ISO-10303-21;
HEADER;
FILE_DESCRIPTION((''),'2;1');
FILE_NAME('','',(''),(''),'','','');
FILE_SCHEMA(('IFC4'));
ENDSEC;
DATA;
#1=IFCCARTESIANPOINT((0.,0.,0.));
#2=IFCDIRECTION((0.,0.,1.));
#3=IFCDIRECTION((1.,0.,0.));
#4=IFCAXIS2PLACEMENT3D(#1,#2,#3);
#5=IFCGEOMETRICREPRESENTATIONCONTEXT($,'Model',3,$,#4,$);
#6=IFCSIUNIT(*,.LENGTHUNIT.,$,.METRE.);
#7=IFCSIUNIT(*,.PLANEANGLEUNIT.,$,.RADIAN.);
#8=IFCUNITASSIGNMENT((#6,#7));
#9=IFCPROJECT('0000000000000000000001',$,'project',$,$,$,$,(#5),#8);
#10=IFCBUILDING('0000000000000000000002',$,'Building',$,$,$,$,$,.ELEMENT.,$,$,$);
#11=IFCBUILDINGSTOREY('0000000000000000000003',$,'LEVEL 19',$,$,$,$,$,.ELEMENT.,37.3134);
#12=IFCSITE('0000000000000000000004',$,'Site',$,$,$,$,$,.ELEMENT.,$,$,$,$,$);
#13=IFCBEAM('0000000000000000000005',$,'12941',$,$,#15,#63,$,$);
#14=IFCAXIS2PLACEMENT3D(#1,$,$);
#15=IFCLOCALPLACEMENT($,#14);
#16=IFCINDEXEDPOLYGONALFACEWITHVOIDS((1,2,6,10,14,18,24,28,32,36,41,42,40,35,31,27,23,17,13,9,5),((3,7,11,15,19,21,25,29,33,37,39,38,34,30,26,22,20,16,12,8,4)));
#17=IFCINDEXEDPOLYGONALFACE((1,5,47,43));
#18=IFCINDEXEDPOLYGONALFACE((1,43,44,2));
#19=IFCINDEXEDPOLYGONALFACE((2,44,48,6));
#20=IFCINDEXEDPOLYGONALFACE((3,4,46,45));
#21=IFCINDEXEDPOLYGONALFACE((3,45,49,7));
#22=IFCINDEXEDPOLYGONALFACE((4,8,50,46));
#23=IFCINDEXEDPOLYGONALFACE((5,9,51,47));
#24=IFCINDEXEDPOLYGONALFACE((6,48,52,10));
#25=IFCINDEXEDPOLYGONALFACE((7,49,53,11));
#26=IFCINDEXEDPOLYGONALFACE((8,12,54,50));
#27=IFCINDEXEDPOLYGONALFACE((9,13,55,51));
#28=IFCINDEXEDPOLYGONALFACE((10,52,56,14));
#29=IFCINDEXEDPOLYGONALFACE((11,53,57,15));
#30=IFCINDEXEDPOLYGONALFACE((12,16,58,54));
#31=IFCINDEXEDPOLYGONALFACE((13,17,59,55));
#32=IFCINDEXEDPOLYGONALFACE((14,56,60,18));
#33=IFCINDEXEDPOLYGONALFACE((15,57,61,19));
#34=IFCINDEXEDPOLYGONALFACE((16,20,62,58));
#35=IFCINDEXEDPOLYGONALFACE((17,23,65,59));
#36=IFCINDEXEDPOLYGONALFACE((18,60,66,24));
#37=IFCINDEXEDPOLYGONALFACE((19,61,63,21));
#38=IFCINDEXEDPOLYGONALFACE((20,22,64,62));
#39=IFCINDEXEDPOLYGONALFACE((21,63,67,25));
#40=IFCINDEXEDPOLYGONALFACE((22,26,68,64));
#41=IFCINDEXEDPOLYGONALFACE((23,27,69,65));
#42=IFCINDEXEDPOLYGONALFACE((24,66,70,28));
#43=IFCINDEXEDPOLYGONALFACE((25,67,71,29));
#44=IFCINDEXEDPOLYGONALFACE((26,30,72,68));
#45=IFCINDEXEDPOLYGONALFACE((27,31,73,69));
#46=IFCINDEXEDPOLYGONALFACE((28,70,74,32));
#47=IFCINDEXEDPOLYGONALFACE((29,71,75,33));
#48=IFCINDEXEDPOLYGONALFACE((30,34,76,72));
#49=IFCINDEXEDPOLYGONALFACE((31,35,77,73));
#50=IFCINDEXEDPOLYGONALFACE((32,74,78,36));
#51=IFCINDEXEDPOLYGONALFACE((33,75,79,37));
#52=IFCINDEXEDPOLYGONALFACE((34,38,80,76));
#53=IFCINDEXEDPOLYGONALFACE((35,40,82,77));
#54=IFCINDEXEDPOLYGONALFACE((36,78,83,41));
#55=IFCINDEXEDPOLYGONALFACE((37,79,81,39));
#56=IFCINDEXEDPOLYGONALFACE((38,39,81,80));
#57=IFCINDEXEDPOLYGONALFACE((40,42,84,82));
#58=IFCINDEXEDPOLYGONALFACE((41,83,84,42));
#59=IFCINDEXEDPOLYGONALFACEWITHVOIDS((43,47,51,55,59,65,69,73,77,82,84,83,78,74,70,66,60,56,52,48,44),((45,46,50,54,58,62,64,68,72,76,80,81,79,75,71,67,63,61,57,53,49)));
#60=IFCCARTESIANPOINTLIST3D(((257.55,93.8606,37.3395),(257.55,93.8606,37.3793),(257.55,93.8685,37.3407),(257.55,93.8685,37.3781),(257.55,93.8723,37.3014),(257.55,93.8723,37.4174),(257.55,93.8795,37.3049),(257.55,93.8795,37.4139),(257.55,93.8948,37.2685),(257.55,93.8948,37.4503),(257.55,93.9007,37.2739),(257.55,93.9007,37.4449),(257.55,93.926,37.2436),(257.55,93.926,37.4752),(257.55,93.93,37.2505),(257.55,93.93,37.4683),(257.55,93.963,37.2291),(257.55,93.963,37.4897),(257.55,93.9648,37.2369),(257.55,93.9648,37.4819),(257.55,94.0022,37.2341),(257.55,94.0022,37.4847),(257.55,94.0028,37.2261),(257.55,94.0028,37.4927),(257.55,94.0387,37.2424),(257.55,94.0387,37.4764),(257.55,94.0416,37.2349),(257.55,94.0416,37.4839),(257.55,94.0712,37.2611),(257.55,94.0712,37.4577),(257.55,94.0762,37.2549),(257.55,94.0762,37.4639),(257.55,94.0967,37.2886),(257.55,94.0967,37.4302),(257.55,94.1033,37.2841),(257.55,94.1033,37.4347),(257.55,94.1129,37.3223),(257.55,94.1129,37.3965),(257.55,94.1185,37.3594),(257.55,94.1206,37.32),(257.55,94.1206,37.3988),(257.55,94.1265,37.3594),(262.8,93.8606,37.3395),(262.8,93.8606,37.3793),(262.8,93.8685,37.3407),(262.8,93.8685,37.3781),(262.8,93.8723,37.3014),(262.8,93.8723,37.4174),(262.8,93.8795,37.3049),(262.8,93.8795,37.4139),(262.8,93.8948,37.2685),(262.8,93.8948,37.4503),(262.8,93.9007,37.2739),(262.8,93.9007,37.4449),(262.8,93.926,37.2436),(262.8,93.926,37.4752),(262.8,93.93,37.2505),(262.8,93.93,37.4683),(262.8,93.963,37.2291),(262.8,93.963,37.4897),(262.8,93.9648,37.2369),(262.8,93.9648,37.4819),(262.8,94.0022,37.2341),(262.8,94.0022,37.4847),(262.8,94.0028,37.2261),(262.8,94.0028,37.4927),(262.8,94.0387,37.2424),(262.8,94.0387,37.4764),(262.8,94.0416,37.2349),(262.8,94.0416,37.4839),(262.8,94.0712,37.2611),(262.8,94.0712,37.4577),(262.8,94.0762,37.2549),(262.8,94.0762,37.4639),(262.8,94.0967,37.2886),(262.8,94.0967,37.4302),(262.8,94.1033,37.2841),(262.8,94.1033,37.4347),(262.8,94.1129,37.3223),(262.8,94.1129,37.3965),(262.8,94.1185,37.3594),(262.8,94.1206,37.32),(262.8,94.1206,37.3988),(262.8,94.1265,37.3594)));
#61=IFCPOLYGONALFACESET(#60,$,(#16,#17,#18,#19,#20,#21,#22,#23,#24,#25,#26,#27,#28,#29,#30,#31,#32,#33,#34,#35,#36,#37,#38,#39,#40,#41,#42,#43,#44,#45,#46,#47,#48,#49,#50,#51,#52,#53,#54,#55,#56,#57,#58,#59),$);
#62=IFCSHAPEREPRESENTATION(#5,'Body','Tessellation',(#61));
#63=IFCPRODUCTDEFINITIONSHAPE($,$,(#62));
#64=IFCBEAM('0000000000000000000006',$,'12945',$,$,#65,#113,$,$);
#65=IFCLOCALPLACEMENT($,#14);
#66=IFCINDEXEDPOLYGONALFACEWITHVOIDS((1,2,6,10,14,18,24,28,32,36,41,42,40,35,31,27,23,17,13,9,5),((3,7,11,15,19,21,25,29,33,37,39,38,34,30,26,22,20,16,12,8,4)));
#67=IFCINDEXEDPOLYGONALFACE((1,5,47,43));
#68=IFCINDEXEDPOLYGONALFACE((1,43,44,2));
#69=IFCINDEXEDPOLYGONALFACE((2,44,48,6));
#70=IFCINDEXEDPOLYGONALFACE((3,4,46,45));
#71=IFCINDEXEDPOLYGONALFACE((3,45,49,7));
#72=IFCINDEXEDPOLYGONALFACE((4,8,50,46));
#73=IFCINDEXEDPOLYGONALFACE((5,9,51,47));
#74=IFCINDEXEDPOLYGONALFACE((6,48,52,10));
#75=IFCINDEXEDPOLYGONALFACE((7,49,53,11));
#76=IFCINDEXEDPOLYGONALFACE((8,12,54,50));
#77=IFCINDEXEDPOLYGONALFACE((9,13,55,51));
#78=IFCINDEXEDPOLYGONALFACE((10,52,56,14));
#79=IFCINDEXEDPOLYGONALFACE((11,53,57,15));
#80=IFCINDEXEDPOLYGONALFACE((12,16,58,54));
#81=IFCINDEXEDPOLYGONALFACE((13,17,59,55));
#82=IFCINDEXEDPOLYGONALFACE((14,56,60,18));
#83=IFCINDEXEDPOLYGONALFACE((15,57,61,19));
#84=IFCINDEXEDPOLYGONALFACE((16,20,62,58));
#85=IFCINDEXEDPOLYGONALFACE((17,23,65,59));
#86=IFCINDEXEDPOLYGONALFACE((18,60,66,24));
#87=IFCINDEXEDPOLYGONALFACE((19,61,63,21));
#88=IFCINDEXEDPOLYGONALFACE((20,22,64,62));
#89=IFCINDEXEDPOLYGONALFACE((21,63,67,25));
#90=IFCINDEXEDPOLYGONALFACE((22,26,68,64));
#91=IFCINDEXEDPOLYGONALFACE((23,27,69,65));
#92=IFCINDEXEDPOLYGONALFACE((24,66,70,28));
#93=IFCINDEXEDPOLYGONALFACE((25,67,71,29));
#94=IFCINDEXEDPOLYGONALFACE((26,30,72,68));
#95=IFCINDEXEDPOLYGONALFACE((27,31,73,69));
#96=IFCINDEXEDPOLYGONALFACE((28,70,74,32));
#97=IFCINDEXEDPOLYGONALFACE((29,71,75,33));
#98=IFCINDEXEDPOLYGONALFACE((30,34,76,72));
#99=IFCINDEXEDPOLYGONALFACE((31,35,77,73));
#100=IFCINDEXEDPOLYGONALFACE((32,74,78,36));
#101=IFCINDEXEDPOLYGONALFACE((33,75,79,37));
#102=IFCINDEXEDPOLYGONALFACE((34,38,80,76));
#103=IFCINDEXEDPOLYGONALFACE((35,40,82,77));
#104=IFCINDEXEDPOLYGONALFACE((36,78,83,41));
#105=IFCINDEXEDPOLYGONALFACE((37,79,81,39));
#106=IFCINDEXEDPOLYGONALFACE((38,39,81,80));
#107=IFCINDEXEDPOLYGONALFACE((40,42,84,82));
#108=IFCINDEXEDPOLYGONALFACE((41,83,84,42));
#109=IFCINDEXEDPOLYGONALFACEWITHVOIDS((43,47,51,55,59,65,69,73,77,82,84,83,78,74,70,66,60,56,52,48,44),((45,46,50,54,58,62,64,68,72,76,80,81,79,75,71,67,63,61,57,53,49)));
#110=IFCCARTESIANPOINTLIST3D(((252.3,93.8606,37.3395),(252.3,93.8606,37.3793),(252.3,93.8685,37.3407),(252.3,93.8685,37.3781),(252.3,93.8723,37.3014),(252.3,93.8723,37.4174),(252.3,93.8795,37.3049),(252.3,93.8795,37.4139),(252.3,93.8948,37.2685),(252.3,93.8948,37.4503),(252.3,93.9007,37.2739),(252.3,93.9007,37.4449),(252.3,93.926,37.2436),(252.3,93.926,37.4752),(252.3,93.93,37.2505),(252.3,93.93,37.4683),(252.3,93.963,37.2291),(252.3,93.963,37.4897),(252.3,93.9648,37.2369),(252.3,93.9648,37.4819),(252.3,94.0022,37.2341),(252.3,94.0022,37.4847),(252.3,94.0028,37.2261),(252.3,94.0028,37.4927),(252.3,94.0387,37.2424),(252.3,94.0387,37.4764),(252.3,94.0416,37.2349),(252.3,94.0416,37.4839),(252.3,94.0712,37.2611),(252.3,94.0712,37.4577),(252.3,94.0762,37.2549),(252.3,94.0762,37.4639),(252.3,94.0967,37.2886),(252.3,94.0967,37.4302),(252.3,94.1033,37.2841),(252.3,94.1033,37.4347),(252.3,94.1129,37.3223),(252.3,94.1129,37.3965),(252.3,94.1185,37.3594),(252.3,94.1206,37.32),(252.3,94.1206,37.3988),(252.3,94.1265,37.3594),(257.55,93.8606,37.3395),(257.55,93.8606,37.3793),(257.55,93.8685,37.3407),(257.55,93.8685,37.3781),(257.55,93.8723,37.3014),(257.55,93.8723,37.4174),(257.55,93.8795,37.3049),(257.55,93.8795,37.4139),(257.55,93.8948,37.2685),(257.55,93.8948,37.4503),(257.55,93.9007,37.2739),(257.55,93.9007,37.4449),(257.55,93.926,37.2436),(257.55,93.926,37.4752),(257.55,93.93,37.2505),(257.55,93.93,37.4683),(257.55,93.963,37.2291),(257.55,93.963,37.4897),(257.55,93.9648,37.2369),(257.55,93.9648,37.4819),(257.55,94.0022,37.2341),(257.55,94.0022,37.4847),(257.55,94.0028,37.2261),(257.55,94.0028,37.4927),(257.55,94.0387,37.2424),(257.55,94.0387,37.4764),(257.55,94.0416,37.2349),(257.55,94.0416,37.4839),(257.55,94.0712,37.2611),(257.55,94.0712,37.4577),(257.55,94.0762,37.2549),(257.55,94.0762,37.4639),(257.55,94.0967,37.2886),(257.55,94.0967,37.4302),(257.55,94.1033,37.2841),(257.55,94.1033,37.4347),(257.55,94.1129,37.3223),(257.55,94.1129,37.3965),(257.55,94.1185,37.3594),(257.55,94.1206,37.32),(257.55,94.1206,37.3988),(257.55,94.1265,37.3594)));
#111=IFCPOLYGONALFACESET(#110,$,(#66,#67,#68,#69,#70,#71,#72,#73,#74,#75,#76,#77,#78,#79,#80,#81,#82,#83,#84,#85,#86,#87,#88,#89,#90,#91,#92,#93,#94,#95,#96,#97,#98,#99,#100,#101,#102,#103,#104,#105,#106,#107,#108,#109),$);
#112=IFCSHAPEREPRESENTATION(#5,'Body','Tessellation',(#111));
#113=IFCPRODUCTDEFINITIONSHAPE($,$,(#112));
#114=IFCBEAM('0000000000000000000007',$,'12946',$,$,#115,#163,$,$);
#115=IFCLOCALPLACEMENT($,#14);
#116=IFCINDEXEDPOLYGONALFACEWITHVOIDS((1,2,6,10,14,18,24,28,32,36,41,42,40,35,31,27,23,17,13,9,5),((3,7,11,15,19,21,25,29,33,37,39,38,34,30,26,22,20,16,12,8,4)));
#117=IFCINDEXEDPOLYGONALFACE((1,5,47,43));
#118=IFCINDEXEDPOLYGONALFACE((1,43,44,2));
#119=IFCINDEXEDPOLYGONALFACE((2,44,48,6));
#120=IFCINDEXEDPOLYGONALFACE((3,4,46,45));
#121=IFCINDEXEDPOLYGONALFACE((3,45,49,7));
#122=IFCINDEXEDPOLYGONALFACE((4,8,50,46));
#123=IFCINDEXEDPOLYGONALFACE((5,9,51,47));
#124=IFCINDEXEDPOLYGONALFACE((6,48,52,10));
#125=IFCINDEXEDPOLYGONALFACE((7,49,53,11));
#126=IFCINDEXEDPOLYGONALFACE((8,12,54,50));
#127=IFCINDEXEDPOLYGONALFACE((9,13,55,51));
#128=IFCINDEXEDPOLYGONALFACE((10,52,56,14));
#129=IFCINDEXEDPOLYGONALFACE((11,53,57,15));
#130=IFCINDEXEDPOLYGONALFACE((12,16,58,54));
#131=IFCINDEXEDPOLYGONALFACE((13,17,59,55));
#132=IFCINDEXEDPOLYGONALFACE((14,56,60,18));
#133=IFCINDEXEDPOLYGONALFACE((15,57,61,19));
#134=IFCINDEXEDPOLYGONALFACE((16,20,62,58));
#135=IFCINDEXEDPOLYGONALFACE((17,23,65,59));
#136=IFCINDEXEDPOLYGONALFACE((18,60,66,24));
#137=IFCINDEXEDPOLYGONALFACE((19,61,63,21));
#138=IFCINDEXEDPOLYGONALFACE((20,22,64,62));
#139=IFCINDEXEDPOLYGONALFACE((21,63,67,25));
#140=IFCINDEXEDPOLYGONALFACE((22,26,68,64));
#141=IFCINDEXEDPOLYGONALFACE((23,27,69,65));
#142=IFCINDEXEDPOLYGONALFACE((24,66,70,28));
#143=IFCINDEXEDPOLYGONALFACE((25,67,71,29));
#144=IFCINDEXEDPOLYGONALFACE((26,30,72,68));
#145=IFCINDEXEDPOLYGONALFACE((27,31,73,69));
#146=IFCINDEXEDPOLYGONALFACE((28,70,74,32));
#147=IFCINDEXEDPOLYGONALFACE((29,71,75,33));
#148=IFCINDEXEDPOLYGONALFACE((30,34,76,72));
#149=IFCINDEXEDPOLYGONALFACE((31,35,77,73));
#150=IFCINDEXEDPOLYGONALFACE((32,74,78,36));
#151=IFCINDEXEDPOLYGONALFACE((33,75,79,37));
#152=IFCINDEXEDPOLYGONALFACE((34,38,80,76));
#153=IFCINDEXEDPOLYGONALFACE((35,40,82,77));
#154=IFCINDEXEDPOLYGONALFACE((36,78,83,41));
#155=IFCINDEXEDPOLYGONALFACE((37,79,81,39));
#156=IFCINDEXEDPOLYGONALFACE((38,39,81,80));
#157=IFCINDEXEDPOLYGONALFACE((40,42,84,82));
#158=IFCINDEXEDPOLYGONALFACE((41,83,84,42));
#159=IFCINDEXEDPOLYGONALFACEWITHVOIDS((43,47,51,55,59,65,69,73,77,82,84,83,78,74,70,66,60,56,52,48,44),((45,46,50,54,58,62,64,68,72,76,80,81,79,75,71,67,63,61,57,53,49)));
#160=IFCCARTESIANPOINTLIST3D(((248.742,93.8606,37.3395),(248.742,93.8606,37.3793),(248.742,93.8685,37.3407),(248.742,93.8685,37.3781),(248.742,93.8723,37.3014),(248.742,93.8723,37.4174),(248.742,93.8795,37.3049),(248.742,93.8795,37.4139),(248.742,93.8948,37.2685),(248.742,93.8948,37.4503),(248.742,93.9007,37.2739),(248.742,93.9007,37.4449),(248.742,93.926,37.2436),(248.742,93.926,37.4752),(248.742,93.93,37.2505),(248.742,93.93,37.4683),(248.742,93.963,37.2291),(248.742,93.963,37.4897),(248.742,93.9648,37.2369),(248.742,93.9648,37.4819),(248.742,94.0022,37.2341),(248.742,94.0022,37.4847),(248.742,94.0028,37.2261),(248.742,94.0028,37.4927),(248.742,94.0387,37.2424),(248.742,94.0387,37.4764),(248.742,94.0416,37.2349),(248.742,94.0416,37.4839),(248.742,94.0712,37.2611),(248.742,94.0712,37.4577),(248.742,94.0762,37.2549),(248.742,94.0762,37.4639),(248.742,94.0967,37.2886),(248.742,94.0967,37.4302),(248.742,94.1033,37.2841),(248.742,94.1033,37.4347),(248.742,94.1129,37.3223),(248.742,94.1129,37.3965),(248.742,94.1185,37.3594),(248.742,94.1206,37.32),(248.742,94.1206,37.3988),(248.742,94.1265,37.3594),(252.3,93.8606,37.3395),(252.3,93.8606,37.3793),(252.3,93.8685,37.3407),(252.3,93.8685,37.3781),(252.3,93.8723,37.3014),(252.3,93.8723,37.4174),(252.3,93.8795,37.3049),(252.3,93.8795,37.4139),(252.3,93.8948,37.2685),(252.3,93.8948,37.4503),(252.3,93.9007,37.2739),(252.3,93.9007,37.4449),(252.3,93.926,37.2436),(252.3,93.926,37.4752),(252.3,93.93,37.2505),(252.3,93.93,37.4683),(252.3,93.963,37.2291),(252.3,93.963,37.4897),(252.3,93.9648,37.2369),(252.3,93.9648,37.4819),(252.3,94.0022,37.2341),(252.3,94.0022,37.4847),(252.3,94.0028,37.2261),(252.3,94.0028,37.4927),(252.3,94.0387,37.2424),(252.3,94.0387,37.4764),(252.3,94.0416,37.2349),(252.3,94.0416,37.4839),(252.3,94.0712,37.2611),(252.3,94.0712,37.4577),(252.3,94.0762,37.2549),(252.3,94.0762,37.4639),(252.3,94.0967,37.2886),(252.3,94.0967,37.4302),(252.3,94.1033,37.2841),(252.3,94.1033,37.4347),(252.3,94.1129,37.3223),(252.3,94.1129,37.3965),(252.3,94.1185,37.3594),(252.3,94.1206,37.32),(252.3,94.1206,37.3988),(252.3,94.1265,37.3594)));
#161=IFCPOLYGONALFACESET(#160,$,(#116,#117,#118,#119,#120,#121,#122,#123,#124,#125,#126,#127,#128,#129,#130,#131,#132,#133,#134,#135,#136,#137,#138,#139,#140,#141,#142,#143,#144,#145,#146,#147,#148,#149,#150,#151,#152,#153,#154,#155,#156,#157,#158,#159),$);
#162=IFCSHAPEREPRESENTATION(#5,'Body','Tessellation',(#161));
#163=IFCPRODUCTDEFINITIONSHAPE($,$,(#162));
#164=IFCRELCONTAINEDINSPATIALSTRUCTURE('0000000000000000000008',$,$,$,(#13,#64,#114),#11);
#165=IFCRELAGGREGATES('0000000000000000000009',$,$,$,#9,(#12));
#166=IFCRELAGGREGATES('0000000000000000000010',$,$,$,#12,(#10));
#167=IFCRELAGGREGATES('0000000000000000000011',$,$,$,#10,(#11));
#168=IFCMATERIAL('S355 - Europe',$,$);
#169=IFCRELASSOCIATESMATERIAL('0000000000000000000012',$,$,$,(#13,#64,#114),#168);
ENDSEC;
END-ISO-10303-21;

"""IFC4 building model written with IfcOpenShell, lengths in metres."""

from ifc_helpers import new_model, si_unit, frame, origin_with_axes, origin_2d_with_axis, place, context, project, spatial, hollow_circle, extrude, material, material_profile, profile_set, profile_usage, element, save


model = new_model("IFC4")

# Units and contexts
model_context = context("Model", 3, world=origin_with_axes())
ifc_project = project(units=[si_unit("LENGTHUNIT", "METRE"), si_unit("PLANEANGLEUNIT", "RADIAN")], contexts=[model_context])

# Site, building, storey
site = spatial("IfcSite", under=ifc_project, Name="Site", CompositionType="ELEMENT")
building = spatial("IfcBuilding", under=site, Name="Building", CompositionType="ELEMENT")
storey = spatial("IfcBuildingStorey", under=building, Name="LEVEL 19", CompositionType="ELEMENT", Elevation=37.3134)

# Beams
ifc_material = material(Name="S355 - Europe")
ifc_material_profile_1 = material_profile(ifc_material, hollow_circle(Radius=0.1337, WallThickness=0.008, at=origin_2d_with_axis()))
ifc_profile_set_1 = profile_set([ifc_material_profile_1])
ifc_profile_usage_1 = profile_usage(ifc_profile_set_1, cardinal=10)
beam_1_placement = place(None, frame((257.55, 93.9928, 37.3594), z_axis=(1.0, 0.0, 0.0), x_axis=(0.0, 1.0, 0.0)))
element("IfcBeam", 1, at=beam_1_placement, inside=storey, material=ifc_profile_usage_1, Name="12941", context=model_context, shape_type="SweptSolid", body=[
    extrude(hollow_circle(Radius=0.1337, WallThickness=0.008, at=origin_2d_with_axis()), origin_with_axes(), (0.0, 0.0, 1.0), 5.25),
])
ifc_material_profile_2 = material_profile(ifc_material, hollow_circle(Radius=0.1337, WallThickness=0.008, at=origin_2d_with_axis()))
ifc_profile_set_2 = profile_set([ifc_material_profile_2])
ifc_profile_usage_2 = profile_usage(ifc_profile_set_2, cardinal=10)
beam_2_placement = place(None, frame((252.3, 93.9928, 37.3594), z_axis=(1.0, 0.0, 0.0), x_axis=(0.0, 1.0, 0.0)))
element("IfcBeam", 2, at=beam_2_placement, inside=storey, material=ifc_profile_usage_2, Name="12945", context=model_context, shape_type="SweptSolid", body=[
    extrude(hollow_circle(Radius=0.1337, WallThickness=0.008, at=origin_2d_with_axis()), origin_with_axes(), (0.0, 0.0, 1.0), 5.25),
])
ifc_material_profile_3 = material_profile(ifc_material, hollow_circle(Radius=0.1337, WallThickness=0.008, at=origin_2d_with_axis()))
ifc_profile_set_3 = profile_set([ifc_material_profile_3])
ifc_profile_usage_3 = profile_usage(ifc_profile_set_3, cardinal=10)
beam_3_placement = place(None, frame((248.742, 93.9928, 37.3594), z_axis=(1.0, 0.0, 0.0), x_axis=(0.0, 1.0, 0.0)))
element("IfcBeam", 3, at=beam_3_placement, inside=storey, material=ifc_profile_usage_3, Name="12946", context=model_context, shape_type="SweptSolid", body=[
    extrude(hollow_circle(Radius=0.1337, WallThickness=0.008, at=origin_2d_with_axis()), origin_with_axes(), (0.0, 0.0, 1.0), 3.558),
])

save(model, "model.ifc")
